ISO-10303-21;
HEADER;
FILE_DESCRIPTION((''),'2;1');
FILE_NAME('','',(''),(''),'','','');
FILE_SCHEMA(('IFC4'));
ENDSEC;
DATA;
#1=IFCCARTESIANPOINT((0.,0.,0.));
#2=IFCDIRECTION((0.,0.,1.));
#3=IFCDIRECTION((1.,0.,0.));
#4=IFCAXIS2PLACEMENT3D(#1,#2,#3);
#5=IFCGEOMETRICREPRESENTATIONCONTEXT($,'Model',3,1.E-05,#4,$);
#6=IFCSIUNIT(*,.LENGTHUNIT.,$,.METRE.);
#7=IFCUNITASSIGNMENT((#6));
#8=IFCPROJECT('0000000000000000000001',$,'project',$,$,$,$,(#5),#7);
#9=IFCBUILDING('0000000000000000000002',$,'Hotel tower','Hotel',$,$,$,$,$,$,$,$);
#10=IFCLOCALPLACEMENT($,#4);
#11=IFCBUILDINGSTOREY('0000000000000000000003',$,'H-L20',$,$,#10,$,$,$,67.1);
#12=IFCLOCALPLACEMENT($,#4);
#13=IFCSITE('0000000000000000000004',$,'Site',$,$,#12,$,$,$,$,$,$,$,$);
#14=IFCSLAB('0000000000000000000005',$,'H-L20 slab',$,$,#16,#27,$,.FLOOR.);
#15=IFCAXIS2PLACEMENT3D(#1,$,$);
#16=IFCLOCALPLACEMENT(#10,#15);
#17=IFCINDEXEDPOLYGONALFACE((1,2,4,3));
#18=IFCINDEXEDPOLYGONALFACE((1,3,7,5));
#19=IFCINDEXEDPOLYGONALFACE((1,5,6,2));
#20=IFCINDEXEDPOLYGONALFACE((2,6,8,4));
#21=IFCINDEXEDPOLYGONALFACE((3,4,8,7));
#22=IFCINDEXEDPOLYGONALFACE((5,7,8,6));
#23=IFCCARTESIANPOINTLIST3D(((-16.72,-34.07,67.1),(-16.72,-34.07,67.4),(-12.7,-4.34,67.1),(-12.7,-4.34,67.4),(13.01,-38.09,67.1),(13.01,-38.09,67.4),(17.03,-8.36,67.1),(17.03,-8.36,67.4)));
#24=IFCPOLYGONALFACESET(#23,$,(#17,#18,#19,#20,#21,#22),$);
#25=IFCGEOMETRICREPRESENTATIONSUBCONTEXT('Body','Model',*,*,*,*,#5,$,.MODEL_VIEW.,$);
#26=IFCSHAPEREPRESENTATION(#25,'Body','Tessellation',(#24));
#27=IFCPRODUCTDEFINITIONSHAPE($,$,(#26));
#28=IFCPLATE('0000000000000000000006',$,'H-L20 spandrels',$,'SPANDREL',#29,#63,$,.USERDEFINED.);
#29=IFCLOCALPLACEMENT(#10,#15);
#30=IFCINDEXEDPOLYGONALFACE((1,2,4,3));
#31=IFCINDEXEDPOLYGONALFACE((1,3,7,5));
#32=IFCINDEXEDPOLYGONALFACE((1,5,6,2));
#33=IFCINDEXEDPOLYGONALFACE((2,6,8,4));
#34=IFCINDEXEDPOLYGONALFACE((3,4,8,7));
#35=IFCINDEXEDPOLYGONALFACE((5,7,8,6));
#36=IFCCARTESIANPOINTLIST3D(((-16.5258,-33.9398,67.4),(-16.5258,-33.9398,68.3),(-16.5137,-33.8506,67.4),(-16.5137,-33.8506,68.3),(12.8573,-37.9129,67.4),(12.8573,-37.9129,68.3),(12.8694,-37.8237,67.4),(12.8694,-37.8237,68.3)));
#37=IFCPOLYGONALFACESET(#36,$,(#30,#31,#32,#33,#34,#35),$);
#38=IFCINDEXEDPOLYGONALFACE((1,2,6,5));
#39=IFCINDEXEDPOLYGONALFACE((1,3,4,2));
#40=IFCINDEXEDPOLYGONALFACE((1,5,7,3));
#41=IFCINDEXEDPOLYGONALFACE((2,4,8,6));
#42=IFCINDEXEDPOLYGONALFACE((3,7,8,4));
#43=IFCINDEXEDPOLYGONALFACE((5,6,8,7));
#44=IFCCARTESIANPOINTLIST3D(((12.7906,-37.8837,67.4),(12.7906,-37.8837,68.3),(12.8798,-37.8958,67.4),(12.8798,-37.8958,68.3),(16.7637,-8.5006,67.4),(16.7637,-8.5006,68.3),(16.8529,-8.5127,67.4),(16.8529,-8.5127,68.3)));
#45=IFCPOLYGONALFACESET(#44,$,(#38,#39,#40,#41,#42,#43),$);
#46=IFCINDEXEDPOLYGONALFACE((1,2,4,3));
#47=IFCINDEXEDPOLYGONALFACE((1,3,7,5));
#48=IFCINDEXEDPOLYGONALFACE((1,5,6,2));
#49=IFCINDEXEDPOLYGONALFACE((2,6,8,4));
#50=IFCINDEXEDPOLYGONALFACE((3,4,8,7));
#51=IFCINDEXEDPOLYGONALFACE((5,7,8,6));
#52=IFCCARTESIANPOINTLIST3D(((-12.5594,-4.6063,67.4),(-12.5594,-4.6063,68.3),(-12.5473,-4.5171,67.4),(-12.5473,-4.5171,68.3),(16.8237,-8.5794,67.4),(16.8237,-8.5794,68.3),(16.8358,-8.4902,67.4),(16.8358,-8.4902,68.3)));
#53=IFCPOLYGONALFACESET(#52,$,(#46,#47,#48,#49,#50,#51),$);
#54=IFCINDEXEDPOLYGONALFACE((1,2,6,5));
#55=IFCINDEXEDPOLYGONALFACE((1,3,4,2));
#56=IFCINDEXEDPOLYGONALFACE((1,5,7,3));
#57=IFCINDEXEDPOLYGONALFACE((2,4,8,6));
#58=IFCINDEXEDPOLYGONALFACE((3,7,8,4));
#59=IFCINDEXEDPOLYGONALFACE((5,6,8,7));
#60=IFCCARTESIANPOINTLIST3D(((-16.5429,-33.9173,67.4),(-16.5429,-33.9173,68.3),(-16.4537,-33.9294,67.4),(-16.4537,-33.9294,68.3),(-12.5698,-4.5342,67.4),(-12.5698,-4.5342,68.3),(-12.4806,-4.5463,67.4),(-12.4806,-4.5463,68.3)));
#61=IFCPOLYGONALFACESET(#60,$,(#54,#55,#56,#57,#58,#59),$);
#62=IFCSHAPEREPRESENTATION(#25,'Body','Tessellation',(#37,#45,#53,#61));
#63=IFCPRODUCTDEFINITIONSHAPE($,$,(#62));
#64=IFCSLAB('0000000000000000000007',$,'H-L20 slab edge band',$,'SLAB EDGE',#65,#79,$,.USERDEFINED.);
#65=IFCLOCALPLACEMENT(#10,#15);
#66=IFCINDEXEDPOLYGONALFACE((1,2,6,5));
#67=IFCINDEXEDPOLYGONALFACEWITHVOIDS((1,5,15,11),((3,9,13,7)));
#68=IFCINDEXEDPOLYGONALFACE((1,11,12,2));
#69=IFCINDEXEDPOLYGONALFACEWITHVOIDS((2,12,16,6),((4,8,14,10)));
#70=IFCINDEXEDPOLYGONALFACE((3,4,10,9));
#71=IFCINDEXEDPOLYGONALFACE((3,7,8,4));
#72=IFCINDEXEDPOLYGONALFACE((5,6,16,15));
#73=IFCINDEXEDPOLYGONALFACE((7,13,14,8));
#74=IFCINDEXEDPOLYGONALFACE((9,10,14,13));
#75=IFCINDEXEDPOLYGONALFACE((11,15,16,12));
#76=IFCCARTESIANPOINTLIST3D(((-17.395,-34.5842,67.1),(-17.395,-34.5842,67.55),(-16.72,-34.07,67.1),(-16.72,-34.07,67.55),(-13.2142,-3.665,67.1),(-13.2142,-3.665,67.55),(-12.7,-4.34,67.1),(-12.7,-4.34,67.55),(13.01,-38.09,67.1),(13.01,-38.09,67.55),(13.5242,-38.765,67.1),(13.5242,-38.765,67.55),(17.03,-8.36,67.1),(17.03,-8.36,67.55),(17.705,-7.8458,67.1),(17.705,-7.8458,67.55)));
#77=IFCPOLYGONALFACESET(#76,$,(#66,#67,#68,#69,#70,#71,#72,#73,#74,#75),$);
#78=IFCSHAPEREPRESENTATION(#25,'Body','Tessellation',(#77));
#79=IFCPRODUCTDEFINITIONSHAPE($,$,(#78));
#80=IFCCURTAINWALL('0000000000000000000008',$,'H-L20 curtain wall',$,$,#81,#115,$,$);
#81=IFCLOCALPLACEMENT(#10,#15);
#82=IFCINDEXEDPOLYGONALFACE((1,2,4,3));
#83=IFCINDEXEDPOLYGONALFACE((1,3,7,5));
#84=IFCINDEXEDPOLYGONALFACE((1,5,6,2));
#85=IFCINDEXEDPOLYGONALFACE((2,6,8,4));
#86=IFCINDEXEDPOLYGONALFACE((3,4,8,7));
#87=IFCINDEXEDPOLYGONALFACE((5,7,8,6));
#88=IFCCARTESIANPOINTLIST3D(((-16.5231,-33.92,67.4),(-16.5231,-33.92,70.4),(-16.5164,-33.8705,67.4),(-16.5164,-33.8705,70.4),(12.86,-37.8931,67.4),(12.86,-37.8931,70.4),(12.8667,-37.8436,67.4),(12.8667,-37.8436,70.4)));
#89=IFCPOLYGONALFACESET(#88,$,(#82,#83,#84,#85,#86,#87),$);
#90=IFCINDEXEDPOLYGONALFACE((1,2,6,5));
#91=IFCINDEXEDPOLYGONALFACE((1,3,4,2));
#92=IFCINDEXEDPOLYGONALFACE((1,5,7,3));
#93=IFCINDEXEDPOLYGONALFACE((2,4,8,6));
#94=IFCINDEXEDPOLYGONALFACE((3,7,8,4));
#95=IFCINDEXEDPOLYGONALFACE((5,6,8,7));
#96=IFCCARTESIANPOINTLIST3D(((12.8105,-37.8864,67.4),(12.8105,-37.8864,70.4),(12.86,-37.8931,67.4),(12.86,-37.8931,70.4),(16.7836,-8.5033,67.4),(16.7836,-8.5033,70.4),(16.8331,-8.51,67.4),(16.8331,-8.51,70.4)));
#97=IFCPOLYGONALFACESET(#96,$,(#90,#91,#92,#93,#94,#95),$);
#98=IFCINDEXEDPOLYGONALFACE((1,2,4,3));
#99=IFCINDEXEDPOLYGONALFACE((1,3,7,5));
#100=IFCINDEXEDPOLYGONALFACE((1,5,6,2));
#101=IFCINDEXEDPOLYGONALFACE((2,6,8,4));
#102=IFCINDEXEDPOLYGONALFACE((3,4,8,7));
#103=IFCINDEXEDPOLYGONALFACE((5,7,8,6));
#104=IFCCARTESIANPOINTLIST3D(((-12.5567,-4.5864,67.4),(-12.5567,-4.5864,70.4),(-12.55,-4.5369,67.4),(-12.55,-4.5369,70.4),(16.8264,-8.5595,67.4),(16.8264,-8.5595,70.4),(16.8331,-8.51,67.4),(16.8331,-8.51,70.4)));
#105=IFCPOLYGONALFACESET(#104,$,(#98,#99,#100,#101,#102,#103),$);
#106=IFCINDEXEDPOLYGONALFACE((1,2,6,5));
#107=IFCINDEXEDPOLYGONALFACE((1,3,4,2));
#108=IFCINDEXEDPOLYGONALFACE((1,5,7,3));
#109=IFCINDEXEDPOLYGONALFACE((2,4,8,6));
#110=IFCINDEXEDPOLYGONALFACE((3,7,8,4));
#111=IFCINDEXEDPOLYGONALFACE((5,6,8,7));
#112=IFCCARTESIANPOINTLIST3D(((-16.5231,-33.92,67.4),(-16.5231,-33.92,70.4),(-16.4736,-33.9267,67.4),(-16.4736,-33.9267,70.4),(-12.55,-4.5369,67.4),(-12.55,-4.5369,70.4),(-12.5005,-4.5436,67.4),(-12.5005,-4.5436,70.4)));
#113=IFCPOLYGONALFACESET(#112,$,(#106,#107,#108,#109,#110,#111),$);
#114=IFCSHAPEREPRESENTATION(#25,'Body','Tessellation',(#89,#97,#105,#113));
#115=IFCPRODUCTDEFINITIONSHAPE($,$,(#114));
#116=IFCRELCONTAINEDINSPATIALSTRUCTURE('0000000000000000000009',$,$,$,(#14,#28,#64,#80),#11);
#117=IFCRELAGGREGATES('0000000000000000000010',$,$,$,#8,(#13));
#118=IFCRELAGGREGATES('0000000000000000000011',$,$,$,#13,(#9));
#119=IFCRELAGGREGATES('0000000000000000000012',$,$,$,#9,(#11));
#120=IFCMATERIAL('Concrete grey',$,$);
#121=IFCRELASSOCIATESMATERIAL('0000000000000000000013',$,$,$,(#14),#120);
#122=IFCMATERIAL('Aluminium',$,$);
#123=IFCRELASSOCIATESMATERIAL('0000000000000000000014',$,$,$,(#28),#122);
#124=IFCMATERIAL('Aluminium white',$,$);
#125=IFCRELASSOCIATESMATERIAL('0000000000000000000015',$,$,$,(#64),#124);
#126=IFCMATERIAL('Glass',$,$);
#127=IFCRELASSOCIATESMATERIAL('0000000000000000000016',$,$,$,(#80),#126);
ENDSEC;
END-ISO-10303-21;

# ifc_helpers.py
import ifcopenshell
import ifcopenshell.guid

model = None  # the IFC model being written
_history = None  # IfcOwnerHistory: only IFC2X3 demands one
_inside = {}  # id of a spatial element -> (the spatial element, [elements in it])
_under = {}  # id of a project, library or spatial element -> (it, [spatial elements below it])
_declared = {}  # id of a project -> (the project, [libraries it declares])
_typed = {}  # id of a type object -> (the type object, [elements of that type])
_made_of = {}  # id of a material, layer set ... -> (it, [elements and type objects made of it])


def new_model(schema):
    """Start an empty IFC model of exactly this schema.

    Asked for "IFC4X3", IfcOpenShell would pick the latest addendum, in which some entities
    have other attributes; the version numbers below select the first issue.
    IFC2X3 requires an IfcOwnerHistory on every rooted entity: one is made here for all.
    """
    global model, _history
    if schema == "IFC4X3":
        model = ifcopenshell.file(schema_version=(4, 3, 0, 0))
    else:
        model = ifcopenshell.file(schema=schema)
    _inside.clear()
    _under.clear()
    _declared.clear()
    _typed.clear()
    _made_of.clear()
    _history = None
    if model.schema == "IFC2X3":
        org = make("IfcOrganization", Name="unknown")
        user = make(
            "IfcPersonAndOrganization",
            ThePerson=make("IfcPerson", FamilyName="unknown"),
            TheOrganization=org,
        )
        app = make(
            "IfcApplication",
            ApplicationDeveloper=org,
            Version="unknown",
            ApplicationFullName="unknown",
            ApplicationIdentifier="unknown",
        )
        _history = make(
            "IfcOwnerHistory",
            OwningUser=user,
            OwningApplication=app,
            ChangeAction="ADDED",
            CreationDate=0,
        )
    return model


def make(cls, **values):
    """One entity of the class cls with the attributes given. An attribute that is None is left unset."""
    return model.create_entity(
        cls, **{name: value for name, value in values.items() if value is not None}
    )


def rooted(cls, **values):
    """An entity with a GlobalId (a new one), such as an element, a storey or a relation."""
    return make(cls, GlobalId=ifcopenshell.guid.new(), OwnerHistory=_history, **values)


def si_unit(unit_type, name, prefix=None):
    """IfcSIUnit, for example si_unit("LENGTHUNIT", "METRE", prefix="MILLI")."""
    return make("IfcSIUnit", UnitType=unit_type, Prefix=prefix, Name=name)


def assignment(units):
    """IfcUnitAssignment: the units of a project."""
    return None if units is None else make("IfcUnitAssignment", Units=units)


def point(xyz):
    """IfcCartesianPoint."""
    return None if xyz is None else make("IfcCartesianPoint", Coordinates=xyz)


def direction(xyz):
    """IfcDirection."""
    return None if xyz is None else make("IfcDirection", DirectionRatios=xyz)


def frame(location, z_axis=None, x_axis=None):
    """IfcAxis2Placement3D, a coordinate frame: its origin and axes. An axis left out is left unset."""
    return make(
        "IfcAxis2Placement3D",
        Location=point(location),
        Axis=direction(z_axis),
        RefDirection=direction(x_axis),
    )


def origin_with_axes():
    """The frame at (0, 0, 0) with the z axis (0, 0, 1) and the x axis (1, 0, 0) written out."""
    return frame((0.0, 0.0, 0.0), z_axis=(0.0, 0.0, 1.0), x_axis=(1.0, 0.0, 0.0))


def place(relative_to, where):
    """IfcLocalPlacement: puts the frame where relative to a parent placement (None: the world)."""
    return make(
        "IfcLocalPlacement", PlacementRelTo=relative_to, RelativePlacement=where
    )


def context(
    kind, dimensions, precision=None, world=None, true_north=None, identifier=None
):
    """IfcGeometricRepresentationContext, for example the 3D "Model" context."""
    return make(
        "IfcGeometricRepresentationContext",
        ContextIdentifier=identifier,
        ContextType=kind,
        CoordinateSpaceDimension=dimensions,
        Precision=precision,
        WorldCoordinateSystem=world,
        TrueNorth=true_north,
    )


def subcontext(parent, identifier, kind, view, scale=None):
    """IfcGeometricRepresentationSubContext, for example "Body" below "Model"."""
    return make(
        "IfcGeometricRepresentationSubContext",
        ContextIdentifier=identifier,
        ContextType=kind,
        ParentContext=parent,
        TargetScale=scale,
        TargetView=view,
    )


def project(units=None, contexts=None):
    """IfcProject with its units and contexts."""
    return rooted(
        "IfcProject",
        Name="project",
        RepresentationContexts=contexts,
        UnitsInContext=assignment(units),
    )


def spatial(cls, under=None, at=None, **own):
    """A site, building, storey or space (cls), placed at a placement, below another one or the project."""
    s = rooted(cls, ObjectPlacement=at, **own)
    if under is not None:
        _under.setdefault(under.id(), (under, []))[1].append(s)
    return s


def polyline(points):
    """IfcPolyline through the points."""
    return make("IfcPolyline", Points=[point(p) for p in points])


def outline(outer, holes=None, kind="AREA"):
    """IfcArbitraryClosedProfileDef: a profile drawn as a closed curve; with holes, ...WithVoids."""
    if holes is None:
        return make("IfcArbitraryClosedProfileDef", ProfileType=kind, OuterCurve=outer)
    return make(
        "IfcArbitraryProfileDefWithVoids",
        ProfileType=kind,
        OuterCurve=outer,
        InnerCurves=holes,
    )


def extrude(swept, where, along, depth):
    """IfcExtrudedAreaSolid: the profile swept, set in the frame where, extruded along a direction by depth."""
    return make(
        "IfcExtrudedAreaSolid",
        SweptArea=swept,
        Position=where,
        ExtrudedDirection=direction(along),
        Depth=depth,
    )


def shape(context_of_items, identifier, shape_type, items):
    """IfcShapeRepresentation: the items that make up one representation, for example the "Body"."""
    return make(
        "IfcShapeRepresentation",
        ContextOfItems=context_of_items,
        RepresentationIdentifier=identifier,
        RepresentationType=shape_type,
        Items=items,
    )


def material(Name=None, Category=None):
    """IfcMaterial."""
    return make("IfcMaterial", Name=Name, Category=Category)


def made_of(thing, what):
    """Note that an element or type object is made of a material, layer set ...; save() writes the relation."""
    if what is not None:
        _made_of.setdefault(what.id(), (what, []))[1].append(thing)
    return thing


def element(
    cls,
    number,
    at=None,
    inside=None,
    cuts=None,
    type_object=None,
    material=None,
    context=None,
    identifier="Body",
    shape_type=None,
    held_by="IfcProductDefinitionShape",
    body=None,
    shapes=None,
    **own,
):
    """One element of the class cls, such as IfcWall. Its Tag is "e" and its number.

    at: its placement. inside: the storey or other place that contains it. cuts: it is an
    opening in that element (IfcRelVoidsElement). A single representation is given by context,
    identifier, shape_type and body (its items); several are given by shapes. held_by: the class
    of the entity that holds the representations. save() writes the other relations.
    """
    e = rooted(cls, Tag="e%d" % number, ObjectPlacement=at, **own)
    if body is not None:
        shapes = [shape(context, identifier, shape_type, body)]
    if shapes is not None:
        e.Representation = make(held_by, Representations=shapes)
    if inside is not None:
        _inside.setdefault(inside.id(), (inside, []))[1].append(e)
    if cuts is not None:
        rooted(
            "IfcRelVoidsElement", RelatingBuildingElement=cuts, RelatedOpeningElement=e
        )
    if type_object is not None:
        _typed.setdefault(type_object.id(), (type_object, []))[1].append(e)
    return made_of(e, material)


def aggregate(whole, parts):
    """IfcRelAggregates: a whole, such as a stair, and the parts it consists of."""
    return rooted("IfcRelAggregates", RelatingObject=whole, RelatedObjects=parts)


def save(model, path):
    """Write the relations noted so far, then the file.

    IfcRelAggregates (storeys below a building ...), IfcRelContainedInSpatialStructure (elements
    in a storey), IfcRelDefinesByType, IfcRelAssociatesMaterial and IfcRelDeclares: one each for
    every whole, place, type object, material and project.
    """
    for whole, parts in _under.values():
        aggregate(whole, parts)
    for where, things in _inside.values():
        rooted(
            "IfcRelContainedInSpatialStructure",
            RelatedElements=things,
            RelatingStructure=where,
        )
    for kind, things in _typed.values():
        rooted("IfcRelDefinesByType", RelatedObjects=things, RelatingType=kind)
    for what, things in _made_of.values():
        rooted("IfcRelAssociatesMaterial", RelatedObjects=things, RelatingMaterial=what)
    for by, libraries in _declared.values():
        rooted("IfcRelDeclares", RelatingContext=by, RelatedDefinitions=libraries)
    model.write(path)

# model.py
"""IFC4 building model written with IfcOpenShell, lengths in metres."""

from ifc_helpers import new_model, si_unit, frame, origin_with_axes, place, context, subcontext, project, spatial, polyline, outline, extrude, material, element, save


model = new_model("IFC4")

# Units and contexts
model_context = context("Model", 3, precision=1e-05, world=origin_with_axes())
body_context = subcontext(model_context, "Body", "Model", "MODEL_VIEW")
ifc_project = project(units=[si_unit("LENGTHUNIT", "METRE")], contexts=[model_context])

# Site, building, storey
site_placement = place(None, origin_with_axes())
site = spatial("IfcSite", under=ifc_project, at=site_placement, Name="Site")
building = spatial("IfcBuilding", under=site, Name="Hotel tower", Description="Hotel")
storey_placement = place(None, origin_with_axes())
storey = spatial("IfcBuildingStorey", under=building, at=storey_placement, Name="H-L20", Elevation=67.1)

# Shared definitions
ifc_material_1 = material(Name="Aluminium")

# Slab
ifc_material_2 = material(Name="Concrete grey")
slab_1_placement = place(storey_placement, origin_with_axes())
element("IfcSlab", 1, at=slab_1_placement, inside=storey, material=ifc_material_2, Name="H-L20 slab", PredefinedType="FLOOR", context=body_context, shape_type="SweptSolid", body=[
    extrude(outline(polyline([(-16.72, -34.07), (13.01, -38.09), (17.03, -8.36), (-12.7, -4.34), (-16.72, -34.07)])), frame((0.0, 0.0, 67.1), z_axis=(0.0, 0.0, 1.0), x_axis=(1.0, 0.0, 0.0)), (0.0, 0.0, 1.0), 0.3),
])

# Plate
plate_placement = place(storey_placement, origin_with_axes())
element("IfcPlate", 2, at=plate_placement, inside=storey, material=ifc_material_1, Name="H-L20 spandrels", ObjectType="SPANDREL", PredefinedType="USERDEFINED", context=body_context, shape_type="SweptSolid", body=[
    extrude(outline(polyline([(-16.5258, -33.9398), (12.8573, -37.9129), (12.8694, -37.8237), (-16.5137, -33.8506), (-16.5258, -33.9398)])), frame((0.0, 0.0, 67.4), z_axis=(0.0, 0.0, 1.0), x_axis=(1.0, 0.0, 0.0)), (0.0, 0.0, 1.0), 0.9),
    extrude(outline(polyline([(12.8798, -37.8958), (16.8529, -8.5127), (16.7637, -8.5006), (12.7906, -37.8837), (12.8798, -37.8958)])), frame((0.0, 0.0, 67.4), z_axis=(0.0, 0.0, 1.0), x_axis=(1.0, 0.0, 0.0)), (0.0, 0.0, 1.0), 0.9),
    extrude(outline(polyline([(16.8358, -8.4902), (-12.5473, -4.5171), (-12.5594, -4.6063), (16.8237, -8.5794), (16.8358, -8.4902)])), frame((0.0, 0.0, 67.4), z_axis=(0.0, 0.0, 1.0), x_axis=(1.0, 0.0, 0.0)), (0.0, 0.0, 1.0), 0.9),
    extrude(outline(polyline([(-12.5698, -4.5342), (-16.5429, -33.9173), (-16.4537, -33.9294), (-12.4806, -4.5463), (-12.5698, -4.5342)])), frame((0.0, 0.0, 67.4), z_axis=(0.0, 0.0, 1.0), x_axis=(1.0, 0.0, 0.0)), (0.0, 0.0, 1.0), 0.9),
])

# Slab
ifc_material_3 = material(Name="Aluminium white")
slab_2_placement = place(storey_placement, origin_with_axes())
element("IfcSlab", 3, at=slab_2_placement, inside=storey, material=ifc_material_3, Name="H-L20 slab edge band", ObjectType="SLAB EDGE", PredefinedType="USERDEFINED", context=body_context, shape_type="SweptSolid", body=[
    extrude(outline(polyline([(-17.395, -34.5842), (13.5242, -38.765), (17.705, -7.8458), (-13.2142, -3.665), (-17.395, -34.5842)]), holes=[polyline([(-16.72, -34.07), (13.01, -38.09), (17.03, -8.36), (-12.7, -4.34), (-16.72, -34.07)])]), frame((0.0, 0.0, 67.1), z_axis=(0.0, 0.0, 1.0), x_axis=(1.0, 0.0, 0.0)), (0.0, 0.0, 1.0), 0.45),
])

# Curtain wall
ifc_material_4 = material(Name="Glass")
curtain_wall_placement = place(storey_placement, origin_with_axes())
element("IfcCurtainWall", 4, at=curtain_wall_placement, inside=storey, material=ifc_material_4, Name="H-L20 curtain wall", context=body_context, shape_type="SweptSolid", body=[
    extrude(outline(polyline([(-16.5231, -33.92), (12.86, -37.8931), (12.8667, -37.8436), (-16.5164, -33.8705), (-16.5231, -33.92)])), frame((0.0, 0.0, 67.4), z_axis=(0.0, 0.0, 1.0), x_axis=(1.0, 0.0, 0.0)), (0.0, 0.0, 1.0), 3.0),
    extrude(outline(polyline([(12.86, -37.8931), (16.8331, -8.51), (16.7836, -8.5033), (12.8105, -37.8864), (12.86, -37.8931)])), frame((0.0, 0.0, 67.4), z_axis=(0.0, 0.0, 1.0), x_axis=(1.0, 0.0, 0.0)), (0.0, 0.0, 1.0), 3.0),
    extrude(outline(polyline([(16.8331, -8.51), (-12.55, -4.5369), (-12.5567, -4.5864), (16.8264, -8.5595), (16.8331, -8.51)])), frame((0.0, 0.0, 67.4), z_axis=(0.0, 0.0, 1.0), x_axis=(1.0, 0.0, 0.0)), (0.0, 0.0, 1.0), 3.0),
    extrude(outline(polyline([(-12.55, -4.5369), (-16.5231, -33.92), (-16.4736, -33.9267), (-12.5005, -4.5436), (-12.55, -4.5369)])), frame((0.0, 0.0, 67.4), z_axis=(0.0, 0.0, 1.0), x_axis=(1.0, 0.0, 0.0)), (0.0, 0.0, 1.0), 3.0),
])

save(model, "model.ifc")
